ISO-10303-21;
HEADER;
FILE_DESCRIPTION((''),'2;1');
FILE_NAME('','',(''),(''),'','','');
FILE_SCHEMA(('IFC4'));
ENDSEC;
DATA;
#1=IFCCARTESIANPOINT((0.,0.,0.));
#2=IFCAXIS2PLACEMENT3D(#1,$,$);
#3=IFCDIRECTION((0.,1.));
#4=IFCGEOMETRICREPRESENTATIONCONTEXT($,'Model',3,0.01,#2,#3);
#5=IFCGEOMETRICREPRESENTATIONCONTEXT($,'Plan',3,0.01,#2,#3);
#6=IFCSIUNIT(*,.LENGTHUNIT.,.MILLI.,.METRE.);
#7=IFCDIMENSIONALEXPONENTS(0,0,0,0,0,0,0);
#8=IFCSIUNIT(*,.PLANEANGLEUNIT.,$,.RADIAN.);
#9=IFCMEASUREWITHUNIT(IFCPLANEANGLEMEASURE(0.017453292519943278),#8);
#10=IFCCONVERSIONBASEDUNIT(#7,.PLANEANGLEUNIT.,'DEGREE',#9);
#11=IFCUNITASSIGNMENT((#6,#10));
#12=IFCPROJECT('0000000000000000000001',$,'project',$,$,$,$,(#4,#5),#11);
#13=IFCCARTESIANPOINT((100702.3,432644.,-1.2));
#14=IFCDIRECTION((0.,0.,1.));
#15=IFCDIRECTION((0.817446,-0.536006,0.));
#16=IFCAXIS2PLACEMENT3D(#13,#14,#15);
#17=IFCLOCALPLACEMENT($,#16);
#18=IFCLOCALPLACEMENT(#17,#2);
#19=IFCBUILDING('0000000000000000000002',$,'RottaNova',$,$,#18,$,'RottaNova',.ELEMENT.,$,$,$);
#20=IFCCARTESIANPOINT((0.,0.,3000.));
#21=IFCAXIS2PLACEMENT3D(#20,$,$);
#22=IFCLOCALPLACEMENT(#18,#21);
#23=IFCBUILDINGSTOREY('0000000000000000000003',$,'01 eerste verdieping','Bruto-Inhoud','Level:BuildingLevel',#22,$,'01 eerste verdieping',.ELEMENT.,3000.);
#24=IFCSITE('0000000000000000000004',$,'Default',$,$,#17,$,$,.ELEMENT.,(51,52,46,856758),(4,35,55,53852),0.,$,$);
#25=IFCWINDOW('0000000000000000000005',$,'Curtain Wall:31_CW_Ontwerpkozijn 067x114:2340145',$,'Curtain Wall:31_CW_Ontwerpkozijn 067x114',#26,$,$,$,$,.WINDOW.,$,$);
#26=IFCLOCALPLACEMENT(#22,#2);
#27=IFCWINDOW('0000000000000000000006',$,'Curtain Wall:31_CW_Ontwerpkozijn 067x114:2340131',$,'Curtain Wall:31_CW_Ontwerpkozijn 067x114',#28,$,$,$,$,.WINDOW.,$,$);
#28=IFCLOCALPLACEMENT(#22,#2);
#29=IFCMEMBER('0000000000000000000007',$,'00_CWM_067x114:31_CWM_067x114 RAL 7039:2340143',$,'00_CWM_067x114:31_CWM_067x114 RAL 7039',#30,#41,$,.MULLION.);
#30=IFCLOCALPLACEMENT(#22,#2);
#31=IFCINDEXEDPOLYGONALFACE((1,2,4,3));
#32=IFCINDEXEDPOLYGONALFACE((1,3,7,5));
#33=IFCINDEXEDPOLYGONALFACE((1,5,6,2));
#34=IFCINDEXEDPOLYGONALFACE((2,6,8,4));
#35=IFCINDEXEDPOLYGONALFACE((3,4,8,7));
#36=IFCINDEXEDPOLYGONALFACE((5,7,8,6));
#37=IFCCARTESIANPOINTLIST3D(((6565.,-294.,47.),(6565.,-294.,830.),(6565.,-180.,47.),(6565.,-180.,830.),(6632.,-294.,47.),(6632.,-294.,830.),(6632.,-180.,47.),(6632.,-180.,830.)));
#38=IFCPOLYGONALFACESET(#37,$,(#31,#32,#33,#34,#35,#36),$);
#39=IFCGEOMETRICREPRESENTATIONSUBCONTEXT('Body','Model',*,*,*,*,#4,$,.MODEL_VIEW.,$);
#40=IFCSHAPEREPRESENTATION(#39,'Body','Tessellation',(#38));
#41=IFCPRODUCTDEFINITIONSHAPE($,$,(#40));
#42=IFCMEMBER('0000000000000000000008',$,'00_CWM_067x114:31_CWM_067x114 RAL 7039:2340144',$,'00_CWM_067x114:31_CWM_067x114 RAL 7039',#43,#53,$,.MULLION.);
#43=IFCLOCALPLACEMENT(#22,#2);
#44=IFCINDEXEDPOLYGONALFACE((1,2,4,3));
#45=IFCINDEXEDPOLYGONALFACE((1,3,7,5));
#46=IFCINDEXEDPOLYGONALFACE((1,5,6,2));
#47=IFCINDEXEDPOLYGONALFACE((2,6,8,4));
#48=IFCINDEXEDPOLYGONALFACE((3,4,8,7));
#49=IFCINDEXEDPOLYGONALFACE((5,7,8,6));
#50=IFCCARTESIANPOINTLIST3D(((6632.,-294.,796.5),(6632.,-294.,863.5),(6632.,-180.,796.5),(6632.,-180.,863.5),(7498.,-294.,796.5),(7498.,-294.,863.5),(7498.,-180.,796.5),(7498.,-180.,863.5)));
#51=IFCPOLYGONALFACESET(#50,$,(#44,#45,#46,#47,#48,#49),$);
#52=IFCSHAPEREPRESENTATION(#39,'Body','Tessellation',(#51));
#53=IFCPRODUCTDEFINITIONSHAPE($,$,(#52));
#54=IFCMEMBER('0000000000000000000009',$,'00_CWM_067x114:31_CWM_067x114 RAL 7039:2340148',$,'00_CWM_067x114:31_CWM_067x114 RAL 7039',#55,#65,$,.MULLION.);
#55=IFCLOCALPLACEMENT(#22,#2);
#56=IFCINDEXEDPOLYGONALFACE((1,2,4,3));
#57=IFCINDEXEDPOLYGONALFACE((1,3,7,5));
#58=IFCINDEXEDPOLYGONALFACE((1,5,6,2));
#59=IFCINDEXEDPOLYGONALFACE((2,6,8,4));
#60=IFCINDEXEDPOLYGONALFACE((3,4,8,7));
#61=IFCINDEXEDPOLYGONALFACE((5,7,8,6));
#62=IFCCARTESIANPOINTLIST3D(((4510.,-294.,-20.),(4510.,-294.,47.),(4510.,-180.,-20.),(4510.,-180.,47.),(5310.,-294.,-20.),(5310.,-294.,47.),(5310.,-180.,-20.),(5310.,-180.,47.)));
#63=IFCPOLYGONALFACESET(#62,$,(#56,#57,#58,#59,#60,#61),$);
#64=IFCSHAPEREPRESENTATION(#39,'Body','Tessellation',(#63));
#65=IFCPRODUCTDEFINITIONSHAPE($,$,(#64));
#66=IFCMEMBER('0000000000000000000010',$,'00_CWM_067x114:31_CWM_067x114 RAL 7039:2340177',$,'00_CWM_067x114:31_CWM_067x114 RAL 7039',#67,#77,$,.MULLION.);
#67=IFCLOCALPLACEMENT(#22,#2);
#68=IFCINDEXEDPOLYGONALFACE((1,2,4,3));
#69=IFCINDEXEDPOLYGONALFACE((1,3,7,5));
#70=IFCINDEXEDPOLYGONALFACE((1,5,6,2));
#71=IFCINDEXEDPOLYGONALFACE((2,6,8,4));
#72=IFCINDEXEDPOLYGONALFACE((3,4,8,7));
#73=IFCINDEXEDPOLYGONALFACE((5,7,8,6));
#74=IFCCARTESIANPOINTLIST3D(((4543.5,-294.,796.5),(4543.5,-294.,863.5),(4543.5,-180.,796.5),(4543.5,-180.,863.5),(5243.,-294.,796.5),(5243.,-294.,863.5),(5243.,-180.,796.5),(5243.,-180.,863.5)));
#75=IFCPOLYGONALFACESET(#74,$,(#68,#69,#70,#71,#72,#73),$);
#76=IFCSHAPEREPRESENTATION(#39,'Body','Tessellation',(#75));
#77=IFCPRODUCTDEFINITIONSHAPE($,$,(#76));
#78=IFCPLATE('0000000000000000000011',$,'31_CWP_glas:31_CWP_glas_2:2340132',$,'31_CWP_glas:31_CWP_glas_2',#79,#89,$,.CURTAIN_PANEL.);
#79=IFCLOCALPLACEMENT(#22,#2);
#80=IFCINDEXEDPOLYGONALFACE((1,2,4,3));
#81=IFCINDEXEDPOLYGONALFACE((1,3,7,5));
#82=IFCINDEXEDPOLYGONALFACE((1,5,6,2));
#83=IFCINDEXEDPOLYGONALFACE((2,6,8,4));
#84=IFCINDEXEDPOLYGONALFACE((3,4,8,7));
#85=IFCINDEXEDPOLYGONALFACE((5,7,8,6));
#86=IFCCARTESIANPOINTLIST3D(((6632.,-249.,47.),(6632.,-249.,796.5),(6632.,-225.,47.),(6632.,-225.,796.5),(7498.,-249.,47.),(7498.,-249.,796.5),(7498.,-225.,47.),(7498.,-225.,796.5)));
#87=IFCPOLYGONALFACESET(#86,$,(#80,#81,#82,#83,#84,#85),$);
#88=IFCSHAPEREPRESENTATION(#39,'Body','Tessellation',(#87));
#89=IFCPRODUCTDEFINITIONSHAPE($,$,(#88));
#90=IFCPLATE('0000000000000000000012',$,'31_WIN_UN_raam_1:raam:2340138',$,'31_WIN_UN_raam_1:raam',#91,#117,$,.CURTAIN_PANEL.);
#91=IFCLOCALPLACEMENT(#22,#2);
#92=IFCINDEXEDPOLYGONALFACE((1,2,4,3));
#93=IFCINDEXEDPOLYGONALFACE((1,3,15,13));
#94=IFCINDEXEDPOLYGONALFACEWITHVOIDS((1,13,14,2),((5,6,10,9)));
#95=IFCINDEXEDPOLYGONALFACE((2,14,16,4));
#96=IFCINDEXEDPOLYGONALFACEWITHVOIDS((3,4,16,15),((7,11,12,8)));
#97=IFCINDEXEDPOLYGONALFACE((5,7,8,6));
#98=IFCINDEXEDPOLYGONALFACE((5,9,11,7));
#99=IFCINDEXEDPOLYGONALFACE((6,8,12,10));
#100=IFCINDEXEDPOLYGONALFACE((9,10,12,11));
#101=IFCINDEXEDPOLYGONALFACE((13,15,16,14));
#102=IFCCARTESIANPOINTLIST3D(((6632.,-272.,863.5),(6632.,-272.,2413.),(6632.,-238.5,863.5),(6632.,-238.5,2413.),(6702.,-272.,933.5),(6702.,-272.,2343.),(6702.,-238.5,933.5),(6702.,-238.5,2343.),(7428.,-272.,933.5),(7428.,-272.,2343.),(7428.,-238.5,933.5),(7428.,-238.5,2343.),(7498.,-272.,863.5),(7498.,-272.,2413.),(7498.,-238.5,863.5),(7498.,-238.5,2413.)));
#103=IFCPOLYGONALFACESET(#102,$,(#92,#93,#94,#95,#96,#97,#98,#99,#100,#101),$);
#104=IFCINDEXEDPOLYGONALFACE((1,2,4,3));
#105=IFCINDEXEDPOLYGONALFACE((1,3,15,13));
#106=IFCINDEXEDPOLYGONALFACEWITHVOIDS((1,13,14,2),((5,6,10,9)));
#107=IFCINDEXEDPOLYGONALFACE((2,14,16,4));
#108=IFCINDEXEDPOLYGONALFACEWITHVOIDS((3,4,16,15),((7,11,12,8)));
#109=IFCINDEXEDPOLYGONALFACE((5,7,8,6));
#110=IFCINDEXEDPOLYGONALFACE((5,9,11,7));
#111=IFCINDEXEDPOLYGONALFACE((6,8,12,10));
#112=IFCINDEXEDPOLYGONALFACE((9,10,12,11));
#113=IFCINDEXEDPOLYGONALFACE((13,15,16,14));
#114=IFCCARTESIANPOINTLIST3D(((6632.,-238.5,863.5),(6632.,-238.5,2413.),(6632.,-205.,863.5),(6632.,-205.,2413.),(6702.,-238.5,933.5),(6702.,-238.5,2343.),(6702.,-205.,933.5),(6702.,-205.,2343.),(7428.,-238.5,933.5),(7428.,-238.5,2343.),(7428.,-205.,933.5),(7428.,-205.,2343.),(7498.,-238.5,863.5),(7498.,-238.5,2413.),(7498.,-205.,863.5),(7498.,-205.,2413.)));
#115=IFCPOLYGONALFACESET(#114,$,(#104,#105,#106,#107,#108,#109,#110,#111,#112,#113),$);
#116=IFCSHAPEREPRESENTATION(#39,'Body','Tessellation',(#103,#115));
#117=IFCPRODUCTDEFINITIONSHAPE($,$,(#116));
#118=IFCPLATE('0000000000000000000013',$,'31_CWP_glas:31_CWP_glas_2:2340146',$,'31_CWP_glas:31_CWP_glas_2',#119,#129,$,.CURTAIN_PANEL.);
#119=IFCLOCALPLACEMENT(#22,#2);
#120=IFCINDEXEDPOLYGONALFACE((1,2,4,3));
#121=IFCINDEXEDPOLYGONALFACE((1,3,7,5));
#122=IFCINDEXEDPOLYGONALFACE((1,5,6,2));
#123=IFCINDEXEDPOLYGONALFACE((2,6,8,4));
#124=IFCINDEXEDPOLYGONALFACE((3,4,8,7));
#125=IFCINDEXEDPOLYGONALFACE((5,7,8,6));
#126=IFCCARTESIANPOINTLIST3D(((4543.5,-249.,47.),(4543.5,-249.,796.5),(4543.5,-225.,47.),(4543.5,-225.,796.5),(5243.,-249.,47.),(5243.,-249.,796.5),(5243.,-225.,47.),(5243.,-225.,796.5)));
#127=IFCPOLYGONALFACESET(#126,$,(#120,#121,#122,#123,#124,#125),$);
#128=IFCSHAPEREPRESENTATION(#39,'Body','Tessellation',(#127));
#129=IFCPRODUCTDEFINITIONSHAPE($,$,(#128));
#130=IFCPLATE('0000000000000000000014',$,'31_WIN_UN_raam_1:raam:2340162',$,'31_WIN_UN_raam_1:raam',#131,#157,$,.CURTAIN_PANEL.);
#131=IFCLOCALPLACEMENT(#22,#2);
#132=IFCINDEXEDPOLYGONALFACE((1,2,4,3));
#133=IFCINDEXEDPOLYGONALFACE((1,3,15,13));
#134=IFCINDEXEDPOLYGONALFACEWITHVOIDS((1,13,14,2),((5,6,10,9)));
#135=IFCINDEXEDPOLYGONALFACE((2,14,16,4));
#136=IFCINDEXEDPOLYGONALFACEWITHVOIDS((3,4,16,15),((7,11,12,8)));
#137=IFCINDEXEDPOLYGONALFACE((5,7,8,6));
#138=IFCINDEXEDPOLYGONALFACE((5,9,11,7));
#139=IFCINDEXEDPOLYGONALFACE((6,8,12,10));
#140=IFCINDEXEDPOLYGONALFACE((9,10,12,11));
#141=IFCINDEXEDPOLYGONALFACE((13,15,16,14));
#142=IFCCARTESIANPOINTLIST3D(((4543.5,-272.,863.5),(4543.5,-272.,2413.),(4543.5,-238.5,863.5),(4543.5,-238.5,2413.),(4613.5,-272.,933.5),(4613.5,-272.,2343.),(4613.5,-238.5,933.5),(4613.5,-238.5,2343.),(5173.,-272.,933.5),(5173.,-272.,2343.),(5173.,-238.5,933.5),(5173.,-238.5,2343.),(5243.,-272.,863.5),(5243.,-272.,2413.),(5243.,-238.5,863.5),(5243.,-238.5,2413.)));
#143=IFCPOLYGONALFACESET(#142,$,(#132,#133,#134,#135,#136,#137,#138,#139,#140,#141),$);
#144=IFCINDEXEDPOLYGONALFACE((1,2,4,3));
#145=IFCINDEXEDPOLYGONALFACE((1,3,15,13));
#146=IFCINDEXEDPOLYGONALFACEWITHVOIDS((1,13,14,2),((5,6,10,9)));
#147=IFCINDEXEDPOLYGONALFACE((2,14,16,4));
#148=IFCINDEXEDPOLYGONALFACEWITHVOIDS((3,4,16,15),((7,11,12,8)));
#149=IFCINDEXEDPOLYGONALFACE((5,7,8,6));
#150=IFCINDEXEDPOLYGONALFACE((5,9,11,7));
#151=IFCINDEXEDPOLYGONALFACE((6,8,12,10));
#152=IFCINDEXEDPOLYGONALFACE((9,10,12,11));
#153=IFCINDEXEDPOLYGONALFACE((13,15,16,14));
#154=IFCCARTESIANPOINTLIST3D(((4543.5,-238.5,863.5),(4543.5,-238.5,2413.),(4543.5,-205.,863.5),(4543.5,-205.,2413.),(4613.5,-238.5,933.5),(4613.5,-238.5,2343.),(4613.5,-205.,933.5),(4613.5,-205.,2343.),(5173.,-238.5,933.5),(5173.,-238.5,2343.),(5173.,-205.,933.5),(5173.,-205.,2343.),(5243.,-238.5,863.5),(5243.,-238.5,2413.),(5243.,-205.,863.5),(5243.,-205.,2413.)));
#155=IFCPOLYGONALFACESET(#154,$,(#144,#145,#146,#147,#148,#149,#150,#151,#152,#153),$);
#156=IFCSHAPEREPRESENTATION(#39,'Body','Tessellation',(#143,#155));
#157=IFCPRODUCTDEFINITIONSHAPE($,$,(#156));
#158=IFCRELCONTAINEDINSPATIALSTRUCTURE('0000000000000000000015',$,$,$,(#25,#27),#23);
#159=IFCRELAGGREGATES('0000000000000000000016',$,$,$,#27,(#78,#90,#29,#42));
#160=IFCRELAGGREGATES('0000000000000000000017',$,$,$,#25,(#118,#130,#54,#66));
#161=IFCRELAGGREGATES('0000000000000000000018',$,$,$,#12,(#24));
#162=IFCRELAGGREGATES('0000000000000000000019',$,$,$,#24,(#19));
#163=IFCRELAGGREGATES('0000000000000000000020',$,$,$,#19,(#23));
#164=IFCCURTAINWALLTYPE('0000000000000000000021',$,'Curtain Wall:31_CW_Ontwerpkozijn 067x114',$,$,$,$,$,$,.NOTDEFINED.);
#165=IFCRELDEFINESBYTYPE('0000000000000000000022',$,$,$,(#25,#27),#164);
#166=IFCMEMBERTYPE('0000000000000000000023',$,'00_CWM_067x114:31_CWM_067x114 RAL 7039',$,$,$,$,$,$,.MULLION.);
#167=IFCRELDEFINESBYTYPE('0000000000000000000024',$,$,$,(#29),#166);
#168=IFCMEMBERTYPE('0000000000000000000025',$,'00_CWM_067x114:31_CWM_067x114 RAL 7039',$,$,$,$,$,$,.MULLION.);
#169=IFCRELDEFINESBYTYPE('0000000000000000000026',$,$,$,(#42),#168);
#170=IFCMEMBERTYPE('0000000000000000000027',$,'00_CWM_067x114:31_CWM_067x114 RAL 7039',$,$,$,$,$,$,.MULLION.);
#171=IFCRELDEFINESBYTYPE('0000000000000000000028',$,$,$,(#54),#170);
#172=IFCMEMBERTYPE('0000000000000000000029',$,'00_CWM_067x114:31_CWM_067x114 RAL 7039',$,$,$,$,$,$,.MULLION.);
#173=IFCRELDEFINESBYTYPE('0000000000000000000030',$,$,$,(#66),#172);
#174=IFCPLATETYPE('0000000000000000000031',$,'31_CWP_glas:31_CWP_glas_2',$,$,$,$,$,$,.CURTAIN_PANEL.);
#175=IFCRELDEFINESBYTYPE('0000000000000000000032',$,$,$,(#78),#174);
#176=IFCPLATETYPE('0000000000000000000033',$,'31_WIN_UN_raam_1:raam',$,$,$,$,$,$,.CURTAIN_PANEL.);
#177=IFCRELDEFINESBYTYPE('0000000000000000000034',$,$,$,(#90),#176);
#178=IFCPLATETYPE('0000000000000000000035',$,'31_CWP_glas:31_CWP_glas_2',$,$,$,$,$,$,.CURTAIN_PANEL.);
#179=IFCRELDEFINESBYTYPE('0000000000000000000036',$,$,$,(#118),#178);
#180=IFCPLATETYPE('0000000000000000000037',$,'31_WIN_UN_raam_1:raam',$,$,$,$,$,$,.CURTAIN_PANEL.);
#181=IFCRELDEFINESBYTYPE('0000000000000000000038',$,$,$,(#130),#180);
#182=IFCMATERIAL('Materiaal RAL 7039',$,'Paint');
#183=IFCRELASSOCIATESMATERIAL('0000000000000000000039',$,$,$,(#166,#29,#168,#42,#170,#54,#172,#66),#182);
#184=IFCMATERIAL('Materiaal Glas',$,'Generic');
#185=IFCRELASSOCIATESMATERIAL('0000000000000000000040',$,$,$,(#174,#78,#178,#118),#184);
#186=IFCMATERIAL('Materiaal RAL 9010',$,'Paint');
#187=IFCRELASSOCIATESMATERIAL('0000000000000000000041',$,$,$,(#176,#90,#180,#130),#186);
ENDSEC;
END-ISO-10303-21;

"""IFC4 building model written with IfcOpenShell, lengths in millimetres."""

from ifc_helpers import new_model, entity, si_unit, converted_unit, direction, frame, origin, place, context, subcontext, project, spatial, indexed_curve, outline, extrude, source, transform, mapped, material, type_object, type_shapes, element, aggregate, save


model = new_model("IFC4")

# Units and contexts
model_context = context("Model", 3, precision=0.01, world=origin(), true_north=direction((0.0, 1.0)))
plan_context = context("Plan", 3, precision=0.01, world=origin(), true_north=direction((0.0, 1.0)))
body_context = subcontext(model_context, "Body", "Model", "MODEL_VIEW")
ifc_project = project(units=[si_unit("LENGTHUNIT", "METRE", prefix="MILLI"), converted_unit("PLANEANGLEUNIT", "DEGREE", entity("IfcPlaneAngleMeasure", 0.017453292519943278), si_unit("PLANEANGLEUNIT", "RADIAN"), dimensions=[0, 0, 0, 0, 0, 0, 0])], contexts=[model_context, plan_context])

# Site, building, storey
site_placement = place(None, frame((100702.3, 432644.0, -1.2), z_axis=(0.0, 0.0, 1.0), x_axis=(0.817446, -0.536006, 0.0)))
site = spatial("IfcSite", under=ifc_project, at=site_placement, Name="Default", CompositionType="ELEMENT", RefLatitude=(51, 52, 46, 856758), RefLongitude=(4, 35, 55, 53852), RefElevation=0.0)
building_placement = place(site_placement, origin())
building = spatial("IfcBuilding", under=site, at=building_placement, Name="RottaNova", LongName="RottaNova", CompositionType="ELEMENT")
storey_placement = place(building_placement, frame((0.0, 0.0, 3000.0)))
storey = spatial("IfcBuildingStorey", under=building, at=storey_placement, Name="01 eerste verdieping", Description="Bruto-Inhoud", ObjectType="Level:BuildingLevel", LongName="01 eerste verdieping", CompositionType="ELEMENT", Elevation=3000.0)

# Windows, members
curtain_wall_type = type_object("IfcCurtainWallType", Name="Curtain Wall:31_CW_Ontwerpkozijn 067x114", PredefinedType="NOTDEFINED")
window_1_placement = place(storey_placement, frame((0.0, 0.0, -3000.0)))
window_1 = element("IfcWindow", 1, at=window_1_placement, inside=storey, type_object=curtain_wall_type, Name="Curtain Wall:31_CW_Ontwerpkozijn 067x114:2340145", ObjectType="Curtain Wall:31_CW_Ontwerpkozijn 067x114", PredefinedType="WINDOW")
ifc_material_1 = material(Name="Materiaal RAL 7039", Category="Paint")
window_2_placement = place(storey_placement, frame((0.0, 0.0, -3000.0)))
window_2 = element("IfcWindow", 2, at=window_2_placement, inside=storey, type_object=curtain_wall_type, Name="Curtain Wall:31_CW_Ontwerpkozijn 067x114:2340131", ObjectType="Curtain Wall:31_CW_Ontwerpkozijn 067x114", PredefinedType="WINDOW")
member_type_1 = type_object("IfcMemberType", Name="00_CWM_067x114:31_CWM_067x114 RAL 7039", PredefinedType="MULLION", material=ifc_material_1)
shared_shape_1 = source(origin(), body_context, "Body", "SweptSolid", [
    extrude(outline(indexed_curve([(-33.5, -57.0), (33.5, -57.0), (33.5, 57.0), (-33.5, 57.0), (-33.5, -57.0)], self_intersect=False)), frame((-33.5, 57.0, -783.0), z_axis=(0.0, 0.0, 1.0), x_axis=(-1.0, 0.0, 0.0)), (0.0, 0.0, 1.0), 783.0),
])
type_shapes(member_type_1, [shared_shape_1])
member_1_placement = place(window_2_placement, frame((6565.0, -180.0, 3830.0), z_axis=(0.0, 0.0, 1.0), x_axis=(-1.0, 0.0, 0.0)))
member_1 = element("IfcMember", 3, at=member_1_placement, type_object=member_type_1, material=ifc_material_1, Name="00_CWM_067x114:31_CWM_067x114 RAL 7039:2340143", ObjectType="00_CWM_067x114:31_CWM_067x114 RAL 7039", PredefinedType="MULLION", context=body_context, shape_type="MappedRepresentation", body=[
    mapped(shared_shape_1, transform((0.0, 0.0, 0.0), scale=1.0)),
])
member_type_2 = type_object("IfcMemberType", Name="00_CWM_067x114:31_CWM_067x114 RAL 7039", PredefinedType="MULLION", material=ifc_material_1)
shared_shape_2 = source(origin(), body_context, "Body", "SweptSolid", [
    extrude(outline(indexed_curve([(-33.5, -57.0), (33.5, -57.0), (33.5, 57.0), (-33.5, 57.0), (-33.5, -57.0)], self_intersect=False)), frame((0.0, 57.0, -866.0), z_axis=(0.0, 0.0, 1.0), x_axis=(-1.0, 0.0, 0.0)), (0.0, 0.0, 1.0), 866.0),
])
type_shapes(member_type_2, [shared_shape_2])
member_2_placement = place(window_2_placement, frame((7498.0, -180.0, 3830.0), z_axis=(1.0, 0.0, 0.0), x_axis=(0.0, 0.0, 1.0)))
member_2 = element("IfcMember", 4, at=member_2_placement, type_object=member_type_2, material=ifc_material_1, Name="00_CWM_067x114:31_CWM_067x114 RAL 7039:2340144", ObjectType="00_CWM_067x114:31_CWM_067x114 RAL 7039", PredefinedType="MULLION", context=body_context, shape_type="MappedRepresentation", body=[
    mapped(shared_shape_2, transform((0.0, 0.0, 0.0), scale=1.0)),
])

# Members
member_type_3 = type_object("IfcMemberType", Name="00_CWM_067x114:31_CWM_067x114 RAL 7039", PredefinedType="MULLION", material=ifc_material_1)
shared_shape_3 = source(origin(), body_context, "Body", "SweptSolid", [
    extrude(outline(indexed_curve([(-33.5, -57.0), (33.5, -57.0), (33.5, 57.0), (-33.5, 57.0), (-33.5, -57.0)], self_intersect=False)), frame((-33.5, -57.0, -800.0), z_axis=(0.0, 0.0, 1.0), x_axis=(-1.0, 0.0, 0.0)), (0.0, 0.0, 1.0), 800.0),
])
type_shapes(member_type_3, [shared_shape_3])
member_3_placement = place(window_1_placement, frame((5310.0, -180.0, 2980.0), z_axis=(1.0, 0.0, 0.0), x_axis=(0.0, 0.0, -1.0)))
member_3 = element("IfcMember", 5, at=member_3_placement, type_object=member_type_3, material=ifc_material_1, Name="00_CWM_067x114:31_CWM_067x114 RAL 7039:2340148", ObjectType="00_CWM_067x114:31_CWM_067x114 RAL 7039", PredefinedType="MULLION", context=body_context, shape_type="MappedRepresentation", body=[
    mapped(shared_shape_3, transform((0.0, 0.0, 0.0), scale=1.0)),
])
member_type_4 = type_object("IfcMemberType", Name="00_CWM_067x114:31_CWM_067x114 RAL 7039", PredefinedType="MULLION", material=ifc_material_1)
shared_shape_4 = source(origin(), body_context, "Body", "SweptSolid", [
    extrude(outline(indexed_curve([(-33.5, -57.0), (33.5, -57.0), (33.5, 57.0), (-33.5, 57.0), (-33.5, -57.0)], self_intersect=False)), frame((0.0, -57.0, -699.5), z_axis=(0.0, 0.0, 1.0), x_axis=(-1.0, 0.0, 0.0)), (0.0, 0.0, 1.0), 699.5),
])
type_shapes(member_type_4, [shared_shape_4])
member_4_placement = place(window_1_placement, frame((4543.5, -180.0, 3830.0), z_axis=(-1.0, 0.0, 0.0), x_axis=(0.0, 0.0, 1.0)))
member_4 = element("IfcMember", 6, at=member_4_placement, type_object=member_type_4, material=ifc_material_1, Name="00_CWM_067x114:31_CWM_067x114 RAL 7039:2340177", ObjectType="00_CWM_067x114:31_CWM_067x114 RAL 7039", PredefinedType="MULLION", context=body_context, shape_type="MappedRepresentation", body=[
    mapped(shared_shape_4, transform((0.0, 0.0, 0.0), scale=1.0)),
])

# Plates
ifc_material_2 = material(Name="Materiaal Glas", Category="Generic")
plate_type_1 = type_object("IfcPlateType", Name="31_CWP_glas:31_CWP_glas_2", PredefinedType="CURTAIN_PANEL", material=ifc_material_2)
shared_shape_5 = source(origin(), body_context, "Body", "SweptSolid", [
    extrude(outline(indexed_curve([(-12.0, -433.0), (12.0, -433.0), (12.0, 433.0), (-12.0, 433.0), (-12.0, -433.0)], self_intersect=False)), frame((0.0, -57.0, 0.0), z_axis=(0.0, 0.0, 1.0), x_axis=(0.0, 1.0, 0.0)), (0.0, 0.0, 1.0), 749.5),
])
type_shapes(plate_type_1, [shared_shape_5])
plate_1_placement = place(window_2_placement, frame((7065.0, -180.0, 3047.0)))
plate_1 = element("IfcPlate", 7, at=plate_1_placement, type_object=plate_type_1, material=ifc_material_2, Name="31_CWP_glas:31_CWP_glas_2:2340132", ObjectType="31_CWP_glas:31_CWP_glas_2", PredefinedType="CURTAIN_PANEL", context=body_context, shape_type="MappedRepresentation", body=[
    mapped(shared_shape_5, transform((0.0, 0.0, 0.0), scale=1.0)),
])
ifc_material_3 = material(Name="Materiaal RAL 9010", Category="Paint")
plate_type_2 = type_object("IfcPlateType", Name="31_WIN_UN_raam_1:raam", PredefinedType="CURTAIN_PANEL", material=ifc_material_3)
shared_shape_6 = source(origin(), body_context, "Body", "SweptSolid", [
    extrude(outline(indexed_curve([(-433.0, -774.7), (433.0, -774.7), (433.0, 774.7), (-433.0, 774.7), (-433.0, -774.7)], self_intersect=False), holes=[indexed_curve([(-363.0, 704.7), (363.0, 704.7), (363.0, -704.8), (-363.0, -704.8), (-363.0, 704.7)], self_intersect=False)]), frame((0.0, -92.0, 774.8), z_axis=(0.0, 1.0, 0.0), x_axis=(1.0, 0.0, 0.0)), (0.0, 0.0, 1.0), 33.5),
    extrude(outline(indexed_curve([(-433.0, -774.7), (433.0, -774.7), (433.0, 774.7), (-433.0, 774.7), (-433.0, -774.7)], self_intersect=False), holes=[indexed_curve([(-363.0, 704.7), (363.0, 704.7), (363.0, -704.8), (-363.0, -704.8), (-363.0, 704.7)], self_intersect=False)]), frame((0.0, -58.5, 774.8), z_axis=(0.0, 1.0, 0.0), x_axis=(1.0, 0.0, 0.0)), (0.0, 0.0, 1.0), 33.5),
])
type_shapes(plate_type_2, [shared_shape_6])
plate_2_placement = place(window_2_placement, frame((7065.0, -180.0, 3863.5)))
plate_2 = element("IfcPlate", 8, at=plate_2_placement, type_object=plate_type_2, material=ifc_material_3, Name="31_WIN_UN_raam_1:raam:2340138", ObjectType="31_WIN_UN_raam_1:raam", PredefinedType="CURTAIN_PANEL", context=body_context, shape_type="MappedRepresentation", body=[
    mapped(shared_shape_6, transform((0.0, 0.0, 0.0), scale=1.0)),
])
aggregate(window_2, [plate_1, plate_2, member_1, member_2])
plate_type_3 = type_object("IfcPlateType", Name="31_CWP_glas:31_CWP_glas_2", PredefinedType="CURTAIN_PANEL", material=ifc_material_2)
shared_shape_7 = source(origin(), body_context, "Body", "SweptSolid", [
    extrude(outline(indexed_curve([(-12.0, -349.8), (12.0, -349.8), (12.0, 349.8), (-12.0, 349.8), (-12.0, -349.8)], self_intersect=False)), frame((0.0, 57.0, 0.0), z_axis=(0.0, 0.0, 1.0), x_axis=(0.0, 1.0, 0.0)), (0.0, 0.0, 1.0), 749.5),
])
type_shapes(plate_type_3, [shared_shape_7])
plate_3_placement = place(window_1_placement, frame((4893.2, -180.0, 3047.0), z_axis=(0.0, 0.0, 1.0), x_axis=(-1.0, 0.0, 0.0)))
plate_3 = element("IfcPlate", 9, at=plate_3_placement, type_object=plate_type_3, material=ifc_material_2, Name="31_CWP_glas:31_CWP_glas_2:2340146", ObjectType="31_CWP_glas:31_CWP_glas_2", PredefinedType="CURTAIN_PANEL", context=body_context, shape_type="MappedRepresentation", body=[
    mapped(shared_shape_7, transform((0.0, 0.0, 0.0), scale=1.0)),
])
plate_type_4 = type_object("IfcPlateType", Name="31_WIN_UN_raam_1:raam", PredefinedType="CURTAIN_PANEL", material=ifc_material_3)
shared_shape_8 = source(origin(), body_context, "Body", "SweptSolid", [
    extrude(outline(indexed_curve([(-349.7, -774.8), (349.7, -774.8), (349.7, 774.8), (-349.7, 774.8), (-349.7, -774.8)], self_intersect=False), holes=[indexed_curve([(-279.7, 704.8), (279.7, 704.8), (279.7, -704.8), (-279.7, -704.8), (-279.7, 704.8)], self_intersect=False)]), frame((0.0, 58.5, 774.8), z_axis=(0.0, 1.0, 0.0), x_axis=(1.0, 0.0, 0.0)), (0.0, 0.0, 1.0), 33.5),
    extrude(outline(indexed_curve([(-349.7, -774.8), (349.7, -774.8), (349.7, 774.8), (-349.7, 774.8), (-349.7, -774.8)], self_intersect=False), holes=[indexed_curve([(-279.7, 704.7), (279.7, 704.7), (279.7, -704.8), (-279.7, -704.8), (-279.7, 704.7)], self_intersect=False)]), frame((0.0, 25.0, 774.8), z_axis=(0.0, 1.0, 0.0), x_axis=(1.0, 0.0, 0.0)), (0.0, 0.0, 1.0), 33.5),
])
type_shapes(plate_type_4, [shared_shape_8])
plate_4_placement = place(window_1_placement, frame((4893.2, -180.0, 3863.5), z_axis=(0.0, 0.0, 1.0), x_axis=(-1.0, 0.0, 0.0)))
plate_4 = element("IfcPlate", 10, at=plate_4_placement, type_object=plate_type_4, material=ifc_material_3, Name="31_WIN_UN_raam_1:raam:2340162", ObjectType="31_WIN_UN_raam_1:raam", PredefinedType="CURTAIN_PANEL", context=body_context, shape_type="MappedRepresentation", body=[
    mapped(shared_shape_8, transform((0.0, 0.0, 0.0), scale=1.0)),
])
aggregate(window_1, [plate_3, plate_4, member_3, member_4])

save(model, "model.ifc")
